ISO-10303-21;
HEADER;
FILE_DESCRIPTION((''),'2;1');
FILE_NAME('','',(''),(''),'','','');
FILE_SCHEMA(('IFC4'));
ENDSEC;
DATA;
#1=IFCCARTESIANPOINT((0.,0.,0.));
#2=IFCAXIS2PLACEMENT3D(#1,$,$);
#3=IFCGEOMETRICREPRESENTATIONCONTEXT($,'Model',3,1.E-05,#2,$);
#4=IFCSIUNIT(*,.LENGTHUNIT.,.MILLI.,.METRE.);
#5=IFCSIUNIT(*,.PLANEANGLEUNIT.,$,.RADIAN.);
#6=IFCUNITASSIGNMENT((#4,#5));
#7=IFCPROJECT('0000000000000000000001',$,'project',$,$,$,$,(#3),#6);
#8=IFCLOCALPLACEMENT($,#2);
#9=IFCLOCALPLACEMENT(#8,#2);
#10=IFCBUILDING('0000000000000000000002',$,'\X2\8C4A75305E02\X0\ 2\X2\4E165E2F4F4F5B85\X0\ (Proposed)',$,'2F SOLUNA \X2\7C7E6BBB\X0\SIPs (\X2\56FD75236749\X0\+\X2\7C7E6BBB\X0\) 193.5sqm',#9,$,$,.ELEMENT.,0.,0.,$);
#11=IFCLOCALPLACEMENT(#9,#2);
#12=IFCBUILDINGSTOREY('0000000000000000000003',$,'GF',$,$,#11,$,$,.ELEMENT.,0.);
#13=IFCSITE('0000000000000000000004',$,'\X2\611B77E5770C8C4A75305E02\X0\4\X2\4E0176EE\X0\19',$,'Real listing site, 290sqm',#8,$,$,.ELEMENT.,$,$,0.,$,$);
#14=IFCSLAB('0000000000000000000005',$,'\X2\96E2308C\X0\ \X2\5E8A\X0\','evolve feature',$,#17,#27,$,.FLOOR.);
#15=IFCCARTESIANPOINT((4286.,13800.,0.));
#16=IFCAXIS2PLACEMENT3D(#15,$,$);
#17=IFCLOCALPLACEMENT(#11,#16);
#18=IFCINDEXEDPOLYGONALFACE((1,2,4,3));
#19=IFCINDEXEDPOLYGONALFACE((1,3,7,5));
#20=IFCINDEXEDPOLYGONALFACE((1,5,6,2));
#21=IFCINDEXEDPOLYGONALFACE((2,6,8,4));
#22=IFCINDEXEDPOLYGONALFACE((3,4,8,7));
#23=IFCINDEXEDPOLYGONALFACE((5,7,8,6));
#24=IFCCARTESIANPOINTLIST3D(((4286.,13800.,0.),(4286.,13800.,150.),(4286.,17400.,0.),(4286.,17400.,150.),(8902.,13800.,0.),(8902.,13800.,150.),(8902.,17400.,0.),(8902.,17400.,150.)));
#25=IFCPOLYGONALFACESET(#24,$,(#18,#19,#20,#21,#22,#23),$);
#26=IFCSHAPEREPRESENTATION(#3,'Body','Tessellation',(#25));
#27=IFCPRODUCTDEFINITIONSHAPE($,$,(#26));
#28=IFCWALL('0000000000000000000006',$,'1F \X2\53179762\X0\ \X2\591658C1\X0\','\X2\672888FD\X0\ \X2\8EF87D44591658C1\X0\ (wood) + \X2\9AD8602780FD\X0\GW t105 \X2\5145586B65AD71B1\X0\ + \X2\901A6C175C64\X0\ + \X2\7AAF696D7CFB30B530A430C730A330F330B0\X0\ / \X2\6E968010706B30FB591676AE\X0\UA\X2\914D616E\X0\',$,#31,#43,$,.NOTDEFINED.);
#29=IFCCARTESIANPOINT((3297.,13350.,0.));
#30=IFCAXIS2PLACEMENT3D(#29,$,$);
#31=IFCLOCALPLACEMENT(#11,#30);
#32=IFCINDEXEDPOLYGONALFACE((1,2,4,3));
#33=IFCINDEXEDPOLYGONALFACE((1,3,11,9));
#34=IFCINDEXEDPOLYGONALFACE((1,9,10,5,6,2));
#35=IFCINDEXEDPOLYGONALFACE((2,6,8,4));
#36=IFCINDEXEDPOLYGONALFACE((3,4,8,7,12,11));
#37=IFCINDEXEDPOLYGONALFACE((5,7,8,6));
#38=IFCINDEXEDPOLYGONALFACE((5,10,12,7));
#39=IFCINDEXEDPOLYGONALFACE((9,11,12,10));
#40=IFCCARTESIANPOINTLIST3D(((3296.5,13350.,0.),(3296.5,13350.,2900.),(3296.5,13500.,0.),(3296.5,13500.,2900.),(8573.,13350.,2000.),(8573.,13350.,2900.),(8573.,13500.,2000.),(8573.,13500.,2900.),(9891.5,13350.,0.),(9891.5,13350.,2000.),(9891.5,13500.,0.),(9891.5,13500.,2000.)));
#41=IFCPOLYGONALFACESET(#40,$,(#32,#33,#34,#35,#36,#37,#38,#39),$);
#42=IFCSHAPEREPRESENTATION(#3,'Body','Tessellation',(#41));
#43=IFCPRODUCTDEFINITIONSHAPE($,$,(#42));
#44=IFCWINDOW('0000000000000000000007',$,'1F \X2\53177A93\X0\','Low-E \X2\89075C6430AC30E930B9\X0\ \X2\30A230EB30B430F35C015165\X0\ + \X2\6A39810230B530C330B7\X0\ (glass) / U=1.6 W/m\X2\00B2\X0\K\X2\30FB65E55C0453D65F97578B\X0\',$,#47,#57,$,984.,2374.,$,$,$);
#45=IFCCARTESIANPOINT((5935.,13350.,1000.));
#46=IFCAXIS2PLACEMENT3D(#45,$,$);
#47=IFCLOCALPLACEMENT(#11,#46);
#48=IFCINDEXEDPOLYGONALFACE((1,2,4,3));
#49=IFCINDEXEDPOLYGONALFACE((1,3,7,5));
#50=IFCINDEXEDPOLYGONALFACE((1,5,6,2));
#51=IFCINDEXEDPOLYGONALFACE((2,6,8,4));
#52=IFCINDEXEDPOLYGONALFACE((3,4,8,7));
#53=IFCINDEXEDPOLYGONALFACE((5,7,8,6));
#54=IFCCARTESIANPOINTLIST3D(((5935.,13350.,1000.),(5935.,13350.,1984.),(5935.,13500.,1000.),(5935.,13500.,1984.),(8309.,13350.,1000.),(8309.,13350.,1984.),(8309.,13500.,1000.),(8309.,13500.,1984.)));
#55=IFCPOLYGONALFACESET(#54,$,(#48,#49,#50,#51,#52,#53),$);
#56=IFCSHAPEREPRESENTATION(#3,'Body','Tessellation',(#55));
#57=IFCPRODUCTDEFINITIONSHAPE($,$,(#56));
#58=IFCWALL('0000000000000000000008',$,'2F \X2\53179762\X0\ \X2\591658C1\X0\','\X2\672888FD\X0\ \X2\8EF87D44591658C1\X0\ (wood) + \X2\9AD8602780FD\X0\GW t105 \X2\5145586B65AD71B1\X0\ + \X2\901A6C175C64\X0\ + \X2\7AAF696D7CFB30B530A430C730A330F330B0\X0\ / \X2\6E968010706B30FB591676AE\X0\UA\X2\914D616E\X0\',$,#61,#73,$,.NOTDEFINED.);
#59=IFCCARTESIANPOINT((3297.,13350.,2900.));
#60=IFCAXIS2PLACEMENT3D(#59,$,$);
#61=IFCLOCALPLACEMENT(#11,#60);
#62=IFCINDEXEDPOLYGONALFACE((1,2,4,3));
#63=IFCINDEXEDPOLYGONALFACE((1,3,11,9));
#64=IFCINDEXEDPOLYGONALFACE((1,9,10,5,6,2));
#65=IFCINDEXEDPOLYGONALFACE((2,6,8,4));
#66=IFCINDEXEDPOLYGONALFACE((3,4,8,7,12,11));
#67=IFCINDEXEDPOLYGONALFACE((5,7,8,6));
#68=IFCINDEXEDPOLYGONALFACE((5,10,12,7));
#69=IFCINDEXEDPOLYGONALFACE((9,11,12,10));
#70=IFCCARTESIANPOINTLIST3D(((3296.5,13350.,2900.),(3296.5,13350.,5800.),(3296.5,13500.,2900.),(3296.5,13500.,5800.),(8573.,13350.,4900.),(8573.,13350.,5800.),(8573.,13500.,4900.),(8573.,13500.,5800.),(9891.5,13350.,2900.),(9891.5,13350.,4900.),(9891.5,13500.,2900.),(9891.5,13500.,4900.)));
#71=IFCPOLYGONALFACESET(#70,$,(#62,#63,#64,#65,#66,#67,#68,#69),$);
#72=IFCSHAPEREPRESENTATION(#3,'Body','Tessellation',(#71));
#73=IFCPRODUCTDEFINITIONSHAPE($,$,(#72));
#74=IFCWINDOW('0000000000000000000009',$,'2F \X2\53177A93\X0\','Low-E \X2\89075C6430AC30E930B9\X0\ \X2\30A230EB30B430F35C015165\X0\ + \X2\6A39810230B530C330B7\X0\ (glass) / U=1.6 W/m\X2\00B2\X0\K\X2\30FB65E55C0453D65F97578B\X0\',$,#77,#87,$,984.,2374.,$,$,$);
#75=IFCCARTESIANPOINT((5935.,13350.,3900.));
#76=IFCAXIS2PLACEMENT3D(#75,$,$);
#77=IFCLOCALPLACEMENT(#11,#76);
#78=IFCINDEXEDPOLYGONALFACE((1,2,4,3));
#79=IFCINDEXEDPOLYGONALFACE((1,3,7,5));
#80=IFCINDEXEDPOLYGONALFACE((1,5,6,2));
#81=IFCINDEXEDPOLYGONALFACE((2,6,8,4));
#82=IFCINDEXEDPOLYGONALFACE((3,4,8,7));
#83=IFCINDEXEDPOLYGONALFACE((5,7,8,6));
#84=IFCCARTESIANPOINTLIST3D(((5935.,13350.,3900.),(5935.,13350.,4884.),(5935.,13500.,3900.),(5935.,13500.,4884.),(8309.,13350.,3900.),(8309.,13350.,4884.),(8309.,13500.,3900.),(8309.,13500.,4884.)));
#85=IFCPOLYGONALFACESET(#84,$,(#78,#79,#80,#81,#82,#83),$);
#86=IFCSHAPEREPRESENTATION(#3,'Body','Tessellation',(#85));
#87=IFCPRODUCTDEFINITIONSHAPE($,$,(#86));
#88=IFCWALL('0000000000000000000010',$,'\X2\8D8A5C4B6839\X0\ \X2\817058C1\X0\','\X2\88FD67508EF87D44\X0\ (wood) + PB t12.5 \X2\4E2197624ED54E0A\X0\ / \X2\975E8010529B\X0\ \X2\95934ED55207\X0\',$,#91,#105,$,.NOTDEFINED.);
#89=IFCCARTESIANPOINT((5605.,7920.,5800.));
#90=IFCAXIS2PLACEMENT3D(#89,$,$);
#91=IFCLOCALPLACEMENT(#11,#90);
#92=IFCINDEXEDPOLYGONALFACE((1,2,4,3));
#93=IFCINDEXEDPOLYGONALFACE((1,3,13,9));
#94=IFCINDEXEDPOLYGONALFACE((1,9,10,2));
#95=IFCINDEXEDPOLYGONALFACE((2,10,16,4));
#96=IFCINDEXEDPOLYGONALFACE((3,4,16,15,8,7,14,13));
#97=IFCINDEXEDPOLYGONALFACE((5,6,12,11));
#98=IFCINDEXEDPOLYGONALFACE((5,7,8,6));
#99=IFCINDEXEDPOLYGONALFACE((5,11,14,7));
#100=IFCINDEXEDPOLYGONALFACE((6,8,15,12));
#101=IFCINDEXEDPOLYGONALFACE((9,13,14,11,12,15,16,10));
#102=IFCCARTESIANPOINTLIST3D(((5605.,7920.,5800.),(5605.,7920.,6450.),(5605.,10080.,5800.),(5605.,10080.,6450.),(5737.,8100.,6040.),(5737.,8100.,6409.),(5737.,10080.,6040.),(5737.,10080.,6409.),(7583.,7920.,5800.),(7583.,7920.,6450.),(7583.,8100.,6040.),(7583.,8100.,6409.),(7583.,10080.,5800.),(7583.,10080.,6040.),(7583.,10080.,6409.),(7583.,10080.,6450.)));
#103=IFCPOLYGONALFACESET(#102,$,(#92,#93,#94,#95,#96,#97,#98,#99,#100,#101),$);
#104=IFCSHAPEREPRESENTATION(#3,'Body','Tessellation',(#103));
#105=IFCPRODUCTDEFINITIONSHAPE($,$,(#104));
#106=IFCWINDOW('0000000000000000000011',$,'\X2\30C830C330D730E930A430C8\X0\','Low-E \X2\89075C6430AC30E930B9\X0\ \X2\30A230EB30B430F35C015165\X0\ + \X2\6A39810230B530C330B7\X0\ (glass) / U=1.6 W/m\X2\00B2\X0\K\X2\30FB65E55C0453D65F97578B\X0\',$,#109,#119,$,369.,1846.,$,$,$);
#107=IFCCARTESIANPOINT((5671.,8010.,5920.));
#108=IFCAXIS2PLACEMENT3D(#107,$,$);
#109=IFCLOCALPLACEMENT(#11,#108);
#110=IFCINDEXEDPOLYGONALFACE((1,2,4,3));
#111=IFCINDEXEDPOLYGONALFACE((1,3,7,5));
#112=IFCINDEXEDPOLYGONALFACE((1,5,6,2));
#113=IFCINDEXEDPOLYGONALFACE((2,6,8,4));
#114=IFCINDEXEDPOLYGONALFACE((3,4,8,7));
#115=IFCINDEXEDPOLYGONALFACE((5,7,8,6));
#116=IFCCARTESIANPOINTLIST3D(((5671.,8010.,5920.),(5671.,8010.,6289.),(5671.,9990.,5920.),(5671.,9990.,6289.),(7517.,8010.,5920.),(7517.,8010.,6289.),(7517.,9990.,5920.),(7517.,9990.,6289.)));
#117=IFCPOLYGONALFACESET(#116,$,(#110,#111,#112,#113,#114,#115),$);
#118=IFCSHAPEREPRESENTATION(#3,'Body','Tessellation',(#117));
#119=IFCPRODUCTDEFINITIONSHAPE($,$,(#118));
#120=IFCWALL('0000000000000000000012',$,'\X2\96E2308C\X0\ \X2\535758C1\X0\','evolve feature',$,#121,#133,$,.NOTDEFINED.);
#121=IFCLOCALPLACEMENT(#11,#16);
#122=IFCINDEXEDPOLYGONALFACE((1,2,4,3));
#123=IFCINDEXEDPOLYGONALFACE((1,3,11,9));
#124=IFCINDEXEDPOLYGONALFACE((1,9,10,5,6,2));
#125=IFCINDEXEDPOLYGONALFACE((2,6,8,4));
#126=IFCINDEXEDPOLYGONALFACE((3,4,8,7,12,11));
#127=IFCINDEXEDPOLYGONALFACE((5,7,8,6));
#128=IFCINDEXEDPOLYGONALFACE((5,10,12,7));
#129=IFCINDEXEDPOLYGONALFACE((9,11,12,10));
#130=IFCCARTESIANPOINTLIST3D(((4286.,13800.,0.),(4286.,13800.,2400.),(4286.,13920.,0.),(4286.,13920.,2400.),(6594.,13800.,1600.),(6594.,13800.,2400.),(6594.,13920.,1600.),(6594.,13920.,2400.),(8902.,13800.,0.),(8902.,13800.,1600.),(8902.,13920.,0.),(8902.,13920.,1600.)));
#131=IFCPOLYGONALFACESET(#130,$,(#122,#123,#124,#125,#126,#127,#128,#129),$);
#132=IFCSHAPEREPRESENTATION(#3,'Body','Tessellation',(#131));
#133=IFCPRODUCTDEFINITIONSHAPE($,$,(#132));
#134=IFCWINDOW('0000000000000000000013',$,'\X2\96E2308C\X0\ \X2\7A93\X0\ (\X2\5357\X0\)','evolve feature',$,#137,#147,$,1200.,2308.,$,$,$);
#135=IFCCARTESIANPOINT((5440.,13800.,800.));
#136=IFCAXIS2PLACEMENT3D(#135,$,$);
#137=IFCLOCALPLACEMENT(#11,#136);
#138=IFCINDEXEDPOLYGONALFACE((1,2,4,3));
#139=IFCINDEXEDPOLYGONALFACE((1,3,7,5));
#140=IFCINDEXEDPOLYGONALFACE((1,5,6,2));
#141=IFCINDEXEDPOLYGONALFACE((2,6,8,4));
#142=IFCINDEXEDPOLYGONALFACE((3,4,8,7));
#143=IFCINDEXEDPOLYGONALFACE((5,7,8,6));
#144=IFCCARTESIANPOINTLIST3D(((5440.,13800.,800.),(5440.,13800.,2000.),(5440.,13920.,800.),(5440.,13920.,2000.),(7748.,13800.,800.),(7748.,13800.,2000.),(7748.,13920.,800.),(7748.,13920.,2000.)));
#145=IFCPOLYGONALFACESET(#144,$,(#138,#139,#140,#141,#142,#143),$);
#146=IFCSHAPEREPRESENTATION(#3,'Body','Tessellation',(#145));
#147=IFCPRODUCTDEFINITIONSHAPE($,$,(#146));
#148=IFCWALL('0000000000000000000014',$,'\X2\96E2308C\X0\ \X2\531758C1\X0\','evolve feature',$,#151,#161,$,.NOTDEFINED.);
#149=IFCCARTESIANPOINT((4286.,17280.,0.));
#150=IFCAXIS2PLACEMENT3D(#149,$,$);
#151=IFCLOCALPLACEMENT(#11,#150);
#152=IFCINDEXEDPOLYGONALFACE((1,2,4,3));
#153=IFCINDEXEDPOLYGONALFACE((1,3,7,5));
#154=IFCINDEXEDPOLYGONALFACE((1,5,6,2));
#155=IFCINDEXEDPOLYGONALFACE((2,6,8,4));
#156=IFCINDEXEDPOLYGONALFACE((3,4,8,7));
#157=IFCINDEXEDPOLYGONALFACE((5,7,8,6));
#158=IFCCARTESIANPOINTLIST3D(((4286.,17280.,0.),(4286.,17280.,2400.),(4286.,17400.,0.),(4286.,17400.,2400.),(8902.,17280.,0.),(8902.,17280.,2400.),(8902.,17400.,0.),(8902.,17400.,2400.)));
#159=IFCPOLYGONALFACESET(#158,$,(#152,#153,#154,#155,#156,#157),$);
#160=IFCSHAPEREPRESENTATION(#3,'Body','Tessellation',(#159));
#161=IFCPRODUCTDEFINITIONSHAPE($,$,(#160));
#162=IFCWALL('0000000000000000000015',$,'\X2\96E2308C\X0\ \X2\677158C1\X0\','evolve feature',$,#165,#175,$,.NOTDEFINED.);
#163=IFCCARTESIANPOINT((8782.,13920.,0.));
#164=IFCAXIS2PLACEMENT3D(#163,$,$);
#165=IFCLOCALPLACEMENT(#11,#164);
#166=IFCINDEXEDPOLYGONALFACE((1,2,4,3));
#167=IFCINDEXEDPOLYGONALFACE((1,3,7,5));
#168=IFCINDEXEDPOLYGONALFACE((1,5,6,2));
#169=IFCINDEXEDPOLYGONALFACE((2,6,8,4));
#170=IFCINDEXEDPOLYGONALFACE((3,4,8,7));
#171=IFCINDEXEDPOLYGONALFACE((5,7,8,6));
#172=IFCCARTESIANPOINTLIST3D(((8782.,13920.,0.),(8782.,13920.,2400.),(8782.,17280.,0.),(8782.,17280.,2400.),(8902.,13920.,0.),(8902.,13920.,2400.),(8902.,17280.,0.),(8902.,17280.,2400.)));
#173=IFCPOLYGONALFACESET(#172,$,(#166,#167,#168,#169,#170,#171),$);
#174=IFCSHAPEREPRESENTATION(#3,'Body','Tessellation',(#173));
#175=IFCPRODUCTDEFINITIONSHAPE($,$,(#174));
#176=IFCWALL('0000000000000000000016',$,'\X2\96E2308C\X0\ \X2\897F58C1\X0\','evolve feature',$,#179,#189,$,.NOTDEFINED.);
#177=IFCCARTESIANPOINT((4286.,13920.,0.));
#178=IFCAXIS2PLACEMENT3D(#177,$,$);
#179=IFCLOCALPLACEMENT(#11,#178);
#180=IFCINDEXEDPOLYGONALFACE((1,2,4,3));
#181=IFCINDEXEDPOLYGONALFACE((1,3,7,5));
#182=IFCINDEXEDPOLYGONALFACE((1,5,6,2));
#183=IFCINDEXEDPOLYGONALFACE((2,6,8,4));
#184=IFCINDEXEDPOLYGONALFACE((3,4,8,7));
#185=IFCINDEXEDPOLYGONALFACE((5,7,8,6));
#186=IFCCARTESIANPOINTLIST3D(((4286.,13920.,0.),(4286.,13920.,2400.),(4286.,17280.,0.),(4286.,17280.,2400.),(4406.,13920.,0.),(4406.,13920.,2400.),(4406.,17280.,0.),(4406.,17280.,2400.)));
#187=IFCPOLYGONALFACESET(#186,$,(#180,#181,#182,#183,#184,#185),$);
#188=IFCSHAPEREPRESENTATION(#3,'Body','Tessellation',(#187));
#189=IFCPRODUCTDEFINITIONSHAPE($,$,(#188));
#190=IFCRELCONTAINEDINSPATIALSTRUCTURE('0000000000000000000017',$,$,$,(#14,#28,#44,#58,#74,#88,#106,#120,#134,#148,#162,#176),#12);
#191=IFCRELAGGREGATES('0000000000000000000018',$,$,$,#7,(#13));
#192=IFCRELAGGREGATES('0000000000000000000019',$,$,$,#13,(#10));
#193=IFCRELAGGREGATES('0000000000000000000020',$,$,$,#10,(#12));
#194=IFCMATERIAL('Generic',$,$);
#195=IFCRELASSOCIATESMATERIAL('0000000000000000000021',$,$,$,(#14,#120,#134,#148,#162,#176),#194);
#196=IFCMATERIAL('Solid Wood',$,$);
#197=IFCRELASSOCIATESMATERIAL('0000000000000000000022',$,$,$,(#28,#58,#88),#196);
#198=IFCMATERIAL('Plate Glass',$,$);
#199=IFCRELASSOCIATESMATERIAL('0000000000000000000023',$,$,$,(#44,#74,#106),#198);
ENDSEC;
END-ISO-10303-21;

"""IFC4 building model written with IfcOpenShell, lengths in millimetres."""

from ifc_helpers import new_model, si_unit, frame, frame_2d, origin, place, context, project, spatial, rectangle, extrude, material, element, fill, save


model = new_model("IFC4")

# Units and contexts
model_context = context("Model", 3, precision=1e-05, world=origin())
ifc_project = project(units=[si_unit("LENGTHUNIT", "METRE", prefix="MILLI"), si_unit("PLANEANGLEUNIT", "RADIAN")], contexts=[model_context])

# Site, building, storey
site_placement = place(None, origin())
site = spatial("IfcSite", under=ifc_project, at=site_placement, Name="愛知県豊田市4丁目19", ObjectType="Real listing site, 290sqm", CompositionType="ELEMENT", RefElevation=0.0)
building_placement = place(site_placement, origin())
building = spatial("IfcBuilding", under=site, at=building_placement, Name="豊田市 2世帯住宅 (Proposed)", ObjectType="2F SOLUNA 籾殻SIPs (国産杉+籾殻) 193.5sqm", CompositionType="ELEMENT", ElevationOfRefHeight=0.0, ElevationOfTerrain=0.0)
storey_placement = place(building_placement, origin())
storey = spatial("IfcBuildingStorey", under=building, at=storey_placement, Name="GF", CompositionType="ELEMENT", Elevation=0.0)

# Slab
ifc_material_1 = material(Name="Generic")
slab_placement = place(storey_placement, frame((4286.0, 13800.0, 0.0)))
element("IfcSlab", 1, at=slab_placement, inside=storey, material=ifc_material_1, Name="離れ 床", Description="evolve feature", PredefinedType="FLOOR", context=model_context, shape_type="SweptSolid", body=[
    extrude(rectangle(XDim=4616.0, YDim=3600.0, at=frame_2d((2308.0, 1800.0))), frame((4286.0, 13800.0, 0.0)), (0.0, 0.0, 1.0), 150.0),
])

# Wall, opening, window
ifc_material_2 = material(Name="Solid Wood")
wall_1_placement = place(storey_placement, frame((3297.0, 13350.0, 0.0)))
wall_1 = element("IfcWall", 2, at=wall_1_placement, inside=storey, material=ifc_material_2, Name="1F 北面 外壁", Description="木製 軸組外壁 (wood) + 高性能GW t105 充填断熱 + 通気層 + 窯業系サイディング / 準耐火・外皮UA配慮", PredefinedType="NOTDEFINED", context=model_context, shape_type="SweptSolid", body=[
    extrude(rectangle(XDim=6595.0, YDim=150.0, at=frame_2d((3297.0, 75.0))), frame((3297.0, 13350.0, 0.0)), (0.0, 0.0, 1.0), 2900.0),
])
opening_1_placement = place(storey_placement, frame((5935.0, 13350.0, 1000.0)))
opening_1 = element("IfcOpeningElement", 3, at=opening_1_placement, cuts=wall_1, PredefinedType="NOTDEFINED", context=model_context, shape_type="SweptSolid", body=[
    extrude(rectangle(XDim=2374.0, YDim=150.0, at=frame_2d((1187.0, 75.0))), frame((5935.0, 13350.0, 1000.0)), (0.0, 0.0, 1.0), 984.0),
])
ifc_material_3 = material(Name="Plate Glass")
window_1_placement = place(storey_placement, frame((5935.0, 13350.0, 1000.0)))
window_1 = element("IfcWindow", 4, at=window_1_placement, inside=storey, material=ifc_material_3, Name="1F 北窓", Description="Low-E 複層ガラス アルゴン封入 + 樹脂サッシ (glass) / U=1.6 W/m²K・日射取得型", OverallHeight=984.0, OverallWidth=2374.0, context=model_context, shape_type="SweptSolid", body=[
    extrude(rectangle(XDim=2374.0, YDim=150.0, at=frame_2d((1187.0, 75.0))), frame((5935.0, 13350.0, 1000.0)), (0.0, 0.0, 1.0), 984.0),
])
fill(opening_1, window_1)

# Wall, opening, window
wall_2_placement = place(storey_placement, frame((3297.0, 13350.0, 2900.0)))
wall_2 = element("IfcWall", 5, at=wall_2_placement, inside=storey, material=ifc_material_2, Name="2F 北面 外壁", Description="木製 軸組外壁 (wood) + 高性能GW t105 充填断熱 + 通気層 + 窯業系サイディング / 準耐火・外皮UA配慮", PredefinedType="NOTDEFINED", context=model_context, shape_type="SweptSolid", body=[
    extrude(rectangle(XDim=6595.0, YDim=150.0, at=frame_2d((3297.0, 75.0))), frame((3297.0, 13350.0, 2900.0)), (0.0, 0.0, 1.0), 2900.0),
])
opening_2_placement = place(storey_placement, frame((5935.0, 13350.0, 3900.0)))
opening_2 = element("IfcOpeningElement", 6, at=opening_2_placement, cuts=wall_2, PredefinedType="NOTDEFINED", context=model_context, shape_type="SweptSolid", body=[
    extrude(rectangle(XDim=2374.0, YDim=150.0, at=frame_2d((1187.0, 75.0))), frame((5935.0, 13350.0, 3900.0)), (0.0, 0.0, 1.0), 984.0),
])
window_2_placement = place(storey_placement, frame((5935.0, 13350.0, 3900.0)))
window_2 = element("IfcWindow", 7, at=window_2_placement, inside=storey, material=ifc_material_3, Name="2F 北窓", Description="Low-E 複層ガラス アルゴン封入 + 樹脂サッシ (glass) / U=1.6 W/m²K・日射取得型", OverallHeight=984.0, OverallWidth=2374.0, context=model_context, shape_type="SweptSolid", body=[
    extrude(rectangle(XDim=2374.0, YDim=150.0, at=frame_2d((1187.0, 75.0))), frame((5935.0, 13350.0, 3900.0)), (0.0, 0.0, 1.0), 984.0),
])
fill(opening_2, window_2)

# Walls, openings, windows
wall_3_placement = place(storey_placement, frame((5605.0, 7920.0, 5800.0)))
wall_3 = element("IfcWall", 8, at=wall_3_placement, inside=storey, material=ifc_material_2, Name="越屋根 腰壁", Description="製材軸組 (wood) + PB t12.5 両面仕上 / 非耐力 間仕切", PredefinedType="NOTDEFINED", context=model_context, shape_type="SweptSolid", body=[
    extrude(rectangle(XDim=1978.0, YDim=2160.0, at=frame_2d((989.0, 1080.0))), frame((5605.0, 7920.0, 5800.0)), (0.0, 0.0, 1.0), 650.0),
])
opening_3_placement = place(storey_placement, frame((5671.0, 8010.0, 5920.0)))
opening_3 = element("IfcOpeningElement", 9, at=opening_3_placement, cuts=wall_3, PredefinedType="NOTDEFINED", context=model_context, shape_type="SweptSolid", body=[
    extrude(rectangle(XDim=1846.0, YDim=1980.0, at=frame_2d((923.0, 990.0))), frame((5671.0, 8010.0, 5920.0)), (0.0, 0.0, 1.0), 369.0),
])
window_3_placement = place(storey_placement, frame((5671.0, 8010.0, 5920.0)))
window_3 = element("IfcWindow", 10, at=window_3_placement, inside=storey, material=ifc_material_3, Name="トップライト", Description="Low-E 複層ガラス アルゴン封入 + 樹脂サッシ (glass) / U=1.6 W/m²K・日射取得型", OverallHeight=369.0, OverallWidth=1846.0, context=model_context, shape_type="SweptSolid", body=[
    extrude(rectangle(XDim=1846.0, YDim=1980.0, at=frame_2d((923.0, 990.0))), frame((5671.0, 8010.0, 5920.0)), (0.0, 0.0, 1.0), 369.0),
])
fill(opening_3, window_3)
wall_4_placement = place(storey_placement, frame((4286.0, 13800.0, 0.0)))
wall_4 = element("IfcWall", 11, at=wall_4_placement, inside=storey, material=ifc_material_1, Name="離れ 南壁", Description="evolve feature", PredefinedType="NOTDEFINED", context=model_context, shape_type="SweptSolid", body=[
    extrude(rectangle(XDim=4616.0, YDim=120.0, at=frame_2d((2308.0, 60.0))), frame((4286.0, 13800.0, 0.0)), (0.0, 0.0, 1.0), 2400.0),
])
opening_4_placement = place(storey_placement, frame((5440.0, 13800.0, 800.0)))
opening_4 = element("IfcOpeningElement", 12, at=opening_4_placement, cuts=wall_4, PredefinedType="NOTDEFINED", context=model_context, shape_type="SweptSolid", body=[
    extrude(rectangle(XDim=2308.0, YDim=120.0, at=frame_2d((1154.0, 60.0))), frame((5440.0, 13800.0, 800.0)), (0.0, 0.0, 1.0), 1200.0),
])
window_4_placement = place(storey_placement, frame((5440.0, 13800.0, 800.0)))
window_4 = element("IfcWindow", 13, at=window_4_placement, inside=storey, material=ifc_material_1, Name="離れ 窓 (南)", Description="evolve feature", OverallHeight=1200.0, OverallWidth=2308.0, context=model_context, shape_type="SweptSolid", body=[
    extrude(rectangle(XDim=2308.0, YDim=120.0, at=frame_2d((1154.0, 60.0))), frame((5440.0, 13800.0, 800.0)), (0.0, 0.0, 1.0), 1200.0),
])
fill(opening_4, window_4)

# Walls
wall_5_placement = place(storey_placement, frame((4286.0, 17280.0, 0.0)))
element("IfcWall", 14, at=wall_5_placement, inside=storey, material=ifc_material_1, Name="離れ 北壁", Description="evolve feature", PredefinedType="NOTDEFINED", context=model_context, shape_type="SweptSolid", body=[
    extrude(rectangle(XDim=4616.0, YDim=120.0, at=frame_2d((2308.0, 60.0))), frame((4286.0, 17280.0, 0.0)), (0.0, 0.0, 1.0), 2400.0),
])
wall_6_placement = place(storey_placement, frame((8782.0, 13920.0, 0.0)))
element("IfcWall", 15, at=wall_6_placement, inside=storey, material=ifc_material_1, Name="離れ 東壁", Description="evolve feature", PredefinedType="NOTDEFINED", context=model_context, shape_type="SweptSolid", body=[
    extrude(rectangle(XDim=120.0, YDim=3360.0, at=frame_2d((60.0, 1680.0))), frame((8782.0, 13920.0, 0.0)), (0.0, 0.0, 1.0), 2400.0),
])
wall_7_placement = place(storey_placement, frame((4286.0, 13920.0, 0.0)))
element("IfcWall", 16, at=wall_7_placement, inside=storey, material=ifc_material_1, Name="離れ 西壁", Description="evolve feature", PredefinedType="NOTDEFINED", context=model_context, shape_type="SweptSolid", body=[
    extrude(rectangle(XDim=120.0, YDim=3360.0, at=frame_2d((60.0, 1680.0))), frame((4286.0, 13920.0, 0.0)), (0.0, 0.0, 1.0), 2400.0),
])

save(model, "model.ifc")
